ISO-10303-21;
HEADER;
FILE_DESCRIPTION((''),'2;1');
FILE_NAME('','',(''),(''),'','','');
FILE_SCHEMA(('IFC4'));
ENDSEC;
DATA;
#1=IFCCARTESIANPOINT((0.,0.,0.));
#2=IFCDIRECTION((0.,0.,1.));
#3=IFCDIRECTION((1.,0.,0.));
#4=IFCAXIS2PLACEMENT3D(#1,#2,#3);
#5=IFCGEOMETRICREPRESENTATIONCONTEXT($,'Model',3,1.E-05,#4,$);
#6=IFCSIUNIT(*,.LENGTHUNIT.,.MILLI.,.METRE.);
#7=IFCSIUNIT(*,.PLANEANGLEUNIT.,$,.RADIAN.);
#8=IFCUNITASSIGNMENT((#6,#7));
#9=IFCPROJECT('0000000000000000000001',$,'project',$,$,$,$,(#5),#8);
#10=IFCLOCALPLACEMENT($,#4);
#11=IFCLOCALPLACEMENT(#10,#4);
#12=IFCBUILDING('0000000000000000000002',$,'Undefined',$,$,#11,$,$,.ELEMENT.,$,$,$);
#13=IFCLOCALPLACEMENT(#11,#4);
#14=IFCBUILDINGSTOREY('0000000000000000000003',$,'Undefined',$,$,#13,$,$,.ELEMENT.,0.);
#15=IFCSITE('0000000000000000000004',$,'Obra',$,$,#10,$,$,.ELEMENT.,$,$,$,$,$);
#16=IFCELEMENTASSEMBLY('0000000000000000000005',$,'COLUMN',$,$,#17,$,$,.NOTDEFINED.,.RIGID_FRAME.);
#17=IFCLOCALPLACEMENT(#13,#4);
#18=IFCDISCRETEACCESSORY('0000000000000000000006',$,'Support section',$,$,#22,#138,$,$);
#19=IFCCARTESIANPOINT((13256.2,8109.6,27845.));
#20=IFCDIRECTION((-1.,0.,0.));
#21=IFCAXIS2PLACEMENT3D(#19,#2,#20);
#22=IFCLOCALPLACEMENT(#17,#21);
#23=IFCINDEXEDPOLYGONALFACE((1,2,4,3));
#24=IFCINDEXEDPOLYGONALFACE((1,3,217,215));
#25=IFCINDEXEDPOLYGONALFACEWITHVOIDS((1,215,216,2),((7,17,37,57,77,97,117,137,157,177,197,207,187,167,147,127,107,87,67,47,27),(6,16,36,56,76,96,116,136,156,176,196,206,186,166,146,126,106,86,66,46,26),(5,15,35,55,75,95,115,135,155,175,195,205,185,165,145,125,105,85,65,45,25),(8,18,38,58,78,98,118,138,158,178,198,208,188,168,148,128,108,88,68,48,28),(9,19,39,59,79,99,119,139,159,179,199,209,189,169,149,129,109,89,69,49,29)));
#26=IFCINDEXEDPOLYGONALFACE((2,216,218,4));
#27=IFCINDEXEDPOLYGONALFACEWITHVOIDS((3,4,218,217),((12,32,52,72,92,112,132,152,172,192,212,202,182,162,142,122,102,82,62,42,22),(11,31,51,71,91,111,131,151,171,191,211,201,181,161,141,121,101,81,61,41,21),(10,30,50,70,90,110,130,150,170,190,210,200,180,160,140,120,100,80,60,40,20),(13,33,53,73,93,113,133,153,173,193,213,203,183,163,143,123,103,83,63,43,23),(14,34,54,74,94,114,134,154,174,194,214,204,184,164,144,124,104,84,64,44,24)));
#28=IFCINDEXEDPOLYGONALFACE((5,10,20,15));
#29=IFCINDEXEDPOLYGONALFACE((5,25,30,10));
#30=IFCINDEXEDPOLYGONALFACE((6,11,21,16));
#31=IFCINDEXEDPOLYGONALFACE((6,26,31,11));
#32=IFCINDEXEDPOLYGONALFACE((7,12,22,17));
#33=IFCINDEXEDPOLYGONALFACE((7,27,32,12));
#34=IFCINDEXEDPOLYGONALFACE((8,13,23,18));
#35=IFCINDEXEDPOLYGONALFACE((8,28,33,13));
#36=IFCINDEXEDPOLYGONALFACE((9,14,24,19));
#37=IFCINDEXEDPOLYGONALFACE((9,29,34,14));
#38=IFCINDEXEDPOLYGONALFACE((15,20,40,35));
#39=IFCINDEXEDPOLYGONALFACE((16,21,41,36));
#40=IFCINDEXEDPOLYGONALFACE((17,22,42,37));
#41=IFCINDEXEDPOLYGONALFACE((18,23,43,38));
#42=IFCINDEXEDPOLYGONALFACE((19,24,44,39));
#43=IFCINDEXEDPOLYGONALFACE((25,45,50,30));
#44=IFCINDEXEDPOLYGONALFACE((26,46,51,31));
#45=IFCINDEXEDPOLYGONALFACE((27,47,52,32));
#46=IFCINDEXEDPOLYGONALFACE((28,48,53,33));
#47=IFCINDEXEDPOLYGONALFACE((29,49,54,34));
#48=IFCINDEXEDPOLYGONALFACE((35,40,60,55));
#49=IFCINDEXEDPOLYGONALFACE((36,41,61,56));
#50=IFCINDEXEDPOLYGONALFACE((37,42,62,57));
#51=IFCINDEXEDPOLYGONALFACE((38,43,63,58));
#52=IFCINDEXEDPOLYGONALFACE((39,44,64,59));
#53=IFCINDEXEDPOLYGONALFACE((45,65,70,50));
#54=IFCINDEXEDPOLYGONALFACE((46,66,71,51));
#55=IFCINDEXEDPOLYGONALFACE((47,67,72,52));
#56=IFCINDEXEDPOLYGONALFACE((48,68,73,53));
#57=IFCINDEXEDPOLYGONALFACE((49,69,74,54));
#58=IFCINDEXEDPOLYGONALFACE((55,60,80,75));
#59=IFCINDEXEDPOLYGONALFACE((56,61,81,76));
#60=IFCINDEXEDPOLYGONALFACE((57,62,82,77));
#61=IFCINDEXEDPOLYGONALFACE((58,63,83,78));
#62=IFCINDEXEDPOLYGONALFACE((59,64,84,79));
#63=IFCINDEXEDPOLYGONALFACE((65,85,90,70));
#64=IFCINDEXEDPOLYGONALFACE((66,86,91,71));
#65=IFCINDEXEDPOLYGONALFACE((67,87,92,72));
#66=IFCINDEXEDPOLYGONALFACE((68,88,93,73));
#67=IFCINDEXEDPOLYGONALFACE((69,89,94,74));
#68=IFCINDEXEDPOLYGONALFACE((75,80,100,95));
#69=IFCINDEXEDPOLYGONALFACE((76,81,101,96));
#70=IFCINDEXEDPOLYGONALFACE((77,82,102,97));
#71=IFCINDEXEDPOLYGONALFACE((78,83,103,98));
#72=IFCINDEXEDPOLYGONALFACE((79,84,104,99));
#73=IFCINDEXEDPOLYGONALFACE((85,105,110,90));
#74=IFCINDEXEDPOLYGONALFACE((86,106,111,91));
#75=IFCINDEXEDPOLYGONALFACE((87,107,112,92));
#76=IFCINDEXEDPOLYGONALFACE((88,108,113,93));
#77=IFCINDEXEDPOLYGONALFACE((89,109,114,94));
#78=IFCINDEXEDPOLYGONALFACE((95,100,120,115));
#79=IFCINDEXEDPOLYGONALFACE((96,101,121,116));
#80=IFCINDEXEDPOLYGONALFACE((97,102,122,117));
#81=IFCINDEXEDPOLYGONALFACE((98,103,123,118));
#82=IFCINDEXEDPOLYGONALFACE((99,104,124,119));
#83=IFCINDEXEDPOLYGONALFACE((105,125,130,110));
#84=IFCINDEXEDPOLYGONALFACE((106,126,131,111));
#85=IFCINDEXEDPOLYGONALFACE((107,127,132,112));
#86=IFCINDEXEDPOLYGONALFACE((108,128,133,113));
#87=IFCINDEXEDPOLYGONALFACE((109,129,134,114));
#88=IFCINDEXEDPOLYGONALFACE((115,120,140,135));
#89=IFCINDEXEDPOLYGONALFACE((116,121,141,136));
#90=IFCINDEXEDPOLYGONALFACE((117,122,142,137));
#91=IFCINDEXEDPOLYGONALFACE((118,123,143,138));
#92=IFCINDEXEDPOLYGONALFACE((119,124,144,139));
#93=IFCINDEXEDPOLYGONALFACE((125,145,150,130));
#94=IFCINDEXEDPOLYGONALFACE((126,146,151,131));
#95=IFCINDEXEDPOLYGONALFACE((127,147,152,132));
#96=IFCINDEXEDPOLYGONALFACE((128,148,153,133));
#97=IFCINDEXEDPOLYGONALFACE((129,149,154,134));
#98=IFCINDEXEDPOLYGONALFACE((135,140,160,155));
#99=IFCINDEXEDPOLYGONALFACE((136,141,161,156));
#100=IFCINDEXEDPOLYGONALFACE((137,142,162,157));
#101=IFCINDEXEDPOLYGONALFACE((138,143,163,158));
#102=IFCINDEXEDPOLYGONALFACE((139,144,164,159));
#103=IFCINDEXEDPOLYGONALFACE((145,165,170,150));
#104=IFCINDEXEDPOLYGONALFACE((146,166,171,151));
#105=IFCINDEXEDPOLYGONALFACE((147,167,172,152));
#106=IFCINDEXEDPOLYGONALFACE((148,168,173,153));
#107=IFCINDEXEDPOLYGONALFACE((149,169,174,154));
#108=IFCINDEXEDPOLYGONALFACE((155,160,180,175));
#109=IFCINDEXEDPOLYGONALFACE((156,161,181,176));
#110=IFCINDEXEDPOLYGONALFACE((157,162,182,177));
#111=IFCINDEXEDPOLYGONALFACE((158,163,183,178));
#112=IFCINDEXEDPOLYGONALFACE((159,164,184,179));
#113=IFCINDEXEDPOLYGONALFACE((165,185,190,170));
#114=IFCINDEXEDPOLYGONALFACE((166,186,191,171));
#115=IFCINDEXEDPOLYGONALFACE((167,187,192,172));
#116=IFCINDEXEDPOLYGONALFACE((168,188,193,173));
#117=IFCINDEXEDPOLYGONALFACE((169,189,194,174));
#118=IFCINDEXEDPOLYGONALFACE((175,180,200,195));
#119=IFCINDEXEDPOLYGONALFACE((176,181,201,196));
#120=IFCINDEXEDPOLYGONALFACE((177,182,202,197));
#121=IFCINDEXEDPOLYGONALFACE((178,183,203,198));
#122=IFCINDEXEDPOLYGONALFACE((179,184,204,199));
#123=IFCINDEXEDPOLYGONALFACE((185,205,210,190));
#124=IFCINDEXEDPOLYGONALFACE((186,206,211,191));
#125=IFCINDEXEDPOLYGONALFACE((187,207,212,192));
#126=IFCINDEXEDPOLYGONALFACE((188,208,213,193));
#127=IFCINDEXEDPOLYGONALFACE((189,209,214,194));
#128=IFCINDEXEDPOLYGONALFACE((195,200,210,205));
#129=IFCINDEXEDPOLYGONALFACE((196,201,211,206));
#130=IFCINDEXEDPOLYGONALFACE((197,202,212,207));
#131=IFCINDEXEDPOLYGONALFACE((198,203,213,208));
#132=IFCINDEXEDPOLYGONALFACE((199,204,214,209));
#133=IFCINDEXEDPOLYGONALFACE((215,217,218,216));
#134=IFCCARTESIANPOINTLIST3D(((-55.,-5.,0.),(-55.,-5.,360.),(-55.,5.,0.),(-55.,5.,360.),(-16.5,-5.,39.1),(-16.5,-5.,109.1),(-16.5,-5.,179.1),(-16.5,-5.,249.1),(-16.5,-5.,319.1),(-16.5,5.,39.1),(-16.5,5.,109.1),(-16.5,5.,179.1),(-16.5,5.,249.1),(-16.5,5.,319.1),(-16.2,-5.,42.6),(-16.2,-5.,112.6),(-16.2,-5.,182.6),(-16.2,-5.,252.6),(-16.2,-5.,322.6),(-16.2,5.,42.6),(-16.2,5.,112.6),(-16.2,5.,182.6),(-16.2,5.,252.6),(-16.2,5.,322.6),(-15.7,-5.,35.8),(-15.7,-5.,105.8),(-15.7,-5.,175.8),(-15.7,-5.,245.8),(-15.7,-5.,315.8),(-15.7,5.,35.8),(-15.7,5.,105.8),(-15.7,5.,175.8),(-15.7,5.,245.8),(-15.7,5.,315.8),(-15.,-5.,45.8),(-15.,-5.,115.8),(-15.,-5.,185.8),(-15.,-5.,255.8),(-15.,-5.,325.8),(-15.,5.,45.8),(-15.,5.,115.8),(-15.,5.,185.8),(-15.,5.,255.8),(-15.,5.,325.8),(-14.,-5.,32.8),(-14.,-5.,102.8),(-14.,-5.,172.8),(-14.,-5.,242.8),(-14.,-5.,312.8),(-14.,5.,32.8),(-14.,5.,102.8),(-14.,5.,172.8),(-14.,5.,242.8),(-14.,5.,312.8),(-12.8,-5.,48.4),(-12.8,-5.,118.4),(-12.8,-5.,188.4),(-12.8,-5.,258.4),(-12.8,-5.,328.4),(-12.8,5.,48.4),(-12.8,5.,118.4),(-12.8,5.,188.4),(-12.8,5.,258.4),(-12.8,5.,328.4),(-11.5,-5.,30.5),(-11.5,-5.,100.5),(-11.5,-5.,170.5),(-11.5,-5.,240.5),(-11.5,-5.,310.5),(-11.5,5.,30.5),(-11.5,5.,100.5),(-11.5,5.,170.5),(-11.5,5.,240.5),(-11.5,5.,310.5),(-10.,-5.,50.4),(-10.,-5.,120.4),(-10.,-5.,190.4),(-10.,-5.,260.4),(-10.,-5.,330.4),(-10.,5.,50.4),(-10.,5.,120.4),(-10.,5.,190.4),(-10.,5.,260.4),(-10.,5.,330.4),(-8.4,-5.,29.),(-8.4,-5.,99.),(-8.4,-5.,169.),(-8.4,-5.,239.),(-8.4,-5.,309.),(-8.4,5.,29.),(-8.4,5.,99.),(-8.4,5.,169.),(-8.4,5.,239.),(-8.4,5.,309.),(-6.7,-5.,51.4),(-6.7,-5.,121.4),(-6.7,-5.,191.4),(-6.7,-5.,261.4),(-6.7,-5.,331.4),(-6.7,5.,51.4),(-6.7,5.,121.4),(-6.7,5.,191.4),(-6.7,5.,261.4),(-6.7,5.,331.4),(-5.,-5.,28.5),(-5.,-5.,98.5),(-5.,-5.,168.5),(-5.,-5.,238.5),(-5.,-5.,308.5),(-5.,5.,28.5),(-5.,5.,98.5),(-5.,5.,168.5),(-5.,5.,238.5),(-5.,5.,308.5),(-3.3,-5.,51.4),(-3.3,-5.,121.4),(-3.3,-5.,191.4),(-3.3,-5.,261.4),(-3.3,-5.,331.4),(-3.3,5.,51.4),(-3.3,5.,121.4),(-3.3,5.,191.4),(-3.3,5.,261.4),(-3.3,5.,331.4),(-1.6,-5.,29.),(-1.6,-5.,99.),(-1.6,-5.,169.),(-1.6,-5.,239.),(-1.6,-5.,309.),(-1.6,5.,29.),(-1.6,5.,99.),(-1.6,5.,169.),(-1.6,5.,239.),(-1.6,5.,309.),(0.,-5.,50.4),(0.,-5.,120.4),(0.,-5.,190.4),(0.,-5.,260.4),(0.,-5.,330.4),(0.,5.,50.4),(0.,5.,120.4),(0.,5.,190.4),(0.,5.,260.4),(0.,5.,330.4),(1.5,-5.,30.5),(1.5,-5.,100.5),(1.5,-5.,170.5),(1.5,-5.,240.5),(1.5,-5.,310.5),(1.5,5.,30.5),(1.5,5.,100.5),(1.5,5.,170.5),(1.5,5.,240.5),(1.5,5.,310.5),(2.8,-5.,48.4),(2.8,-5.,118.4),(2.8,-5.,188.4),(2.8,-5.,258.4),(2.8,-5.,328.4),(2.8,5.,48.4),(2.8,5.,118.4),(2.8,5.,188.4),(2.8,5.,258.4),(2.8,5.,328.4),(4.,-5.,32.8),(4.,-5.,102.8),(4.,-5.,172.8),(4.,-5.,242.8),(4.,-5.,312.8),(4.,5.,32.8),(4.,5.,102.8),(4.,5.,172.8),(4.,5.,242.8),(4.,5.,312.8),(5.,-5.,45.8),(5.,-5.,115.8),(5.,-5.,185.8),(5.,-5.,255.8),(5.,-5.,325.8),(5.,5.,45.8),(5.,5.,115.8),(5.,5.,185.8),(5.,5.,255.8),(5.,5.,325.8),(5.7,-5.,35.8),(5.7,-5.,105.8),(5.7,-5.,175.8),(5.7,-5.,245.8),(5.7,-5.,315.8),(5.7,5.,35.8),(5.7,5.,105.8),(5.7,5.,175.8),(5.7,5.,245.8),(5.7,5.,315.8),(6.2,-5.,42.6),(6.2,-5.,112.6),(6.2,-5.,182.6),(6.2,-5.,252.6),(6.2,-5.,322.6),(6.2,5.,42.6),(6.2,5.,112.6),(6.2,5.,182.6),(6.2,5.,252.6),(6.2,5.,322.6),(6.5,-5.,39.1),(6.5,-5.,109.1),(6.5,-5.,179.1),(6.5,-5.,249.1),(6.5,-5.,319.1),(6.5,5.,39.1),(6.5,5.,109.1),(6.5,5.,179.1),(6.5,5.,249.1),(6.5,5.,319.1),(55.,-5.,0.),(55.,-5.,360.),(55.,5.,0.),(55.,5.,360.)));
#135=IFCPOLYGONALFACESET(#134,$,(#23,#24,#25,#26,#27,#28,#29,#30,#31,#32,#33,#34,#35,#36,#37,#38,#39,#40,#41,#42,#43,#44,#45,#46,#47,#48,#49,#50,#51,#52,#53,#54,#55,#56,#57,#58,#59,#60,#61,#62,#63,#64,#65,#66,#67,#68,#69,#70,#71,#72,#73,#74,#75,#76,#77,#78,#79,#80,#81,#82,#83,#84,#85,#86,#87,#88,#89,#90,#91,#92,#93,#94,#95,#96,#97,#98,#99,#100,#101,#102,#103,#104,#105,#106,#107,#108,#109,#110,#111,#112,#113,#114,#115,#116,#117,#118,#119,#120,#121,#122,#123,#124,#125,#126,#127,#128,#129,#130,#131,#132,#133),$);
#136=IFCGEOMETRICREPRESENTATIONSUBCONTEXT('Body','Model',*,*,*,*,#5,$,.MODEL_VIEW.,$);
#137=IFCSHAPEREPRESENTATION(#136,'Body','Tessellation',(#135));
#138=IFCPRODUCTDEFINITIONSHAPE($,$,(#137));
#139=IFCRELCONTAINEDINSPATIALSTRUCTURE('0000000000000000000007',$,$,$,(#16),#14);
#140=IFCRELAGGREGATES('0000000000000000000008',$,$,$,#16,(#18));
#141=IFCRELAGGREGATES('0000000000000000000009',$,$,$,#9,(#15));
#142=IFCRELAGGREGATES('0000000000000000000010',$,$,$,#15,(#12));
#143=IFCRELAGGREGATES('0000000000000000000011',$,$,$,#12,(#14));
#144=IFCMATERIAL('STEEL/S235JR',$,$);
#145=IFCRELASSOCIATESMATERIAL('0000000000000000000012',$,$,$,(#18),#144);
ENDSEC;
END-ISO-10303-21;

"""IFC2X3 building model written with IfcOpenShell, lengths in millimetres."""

from ifc_helpers import new_model, si_unit, frame, origin_with_axes, origin_2d_with_axis, place, context, subcontext, project, spatial, rectangle, circle, extrude, source, transform, mapped, material, element, aggregate, save


model = new_model("IFC2X3")

# Units and contexts
model_context = context("Model", 3, precision=1e-05, world=origin_with_axes())
body_context = subcontext(model_context, "Body", "Model", "MODEL_VIEW")
ifc_project = project(units=[si_unit("LENGTHUNIT", "METRE", prefix="MILLI"), si_unit("PLANEANGLEUNIT", "RADIAN")], contexts=[model_context])

# Site, building, storey
site_placement = place(None, origin_with_axes())
site = spatial("IfcSite", under=ifc_project, at=site_placement, Name="Obra", CompositionType="ELEMENT")
building_placement = place(site_placement, origin_with_axes())
building = spatial("IfcBuilding", under=site, at=building_placement, Name="Undefined", CompositionType="ELEMENT")
storey_placement = place(building_placement, origin_with_axes())
storey = spatial("IfcBuildingStorey", under=building, at=storey_placement, Name="Undefined", CompositionType="ELEMENT", Elevation=0.0)

# Element assembly
ifc_material_1 = material(Name="STEEL/S235JR")
assembly_1_placement = place(storey_placement, origin_with_axes())
assembly_1 = element("IfcElementAssembly", 1, at=assembly_1_placement, inside=storey, Name="COLUMN", AssemblyPlace="NOTDEFINED", PredefinedType="RIGID_FRAME")

# Discrete accessory, opening
shared_shape_1 = source(origin_with_axes(), body_context, "Body", "SweptSolid", [
    extrude(circle(Radius=11.5, at=origin_2d_with_axis()), frame((0.0, -15.7, 0.0), z_axis=(0.0, 1.0, 0.0), x_axis=(1.0, 0.0, 0.0)), (0.0, 0.0, 1.0), 10.2),
])
discrete_accessory_1_placement = place(assembly_1_placement, frame((13256.2, 8109.6, 27845.0), z_axis=(0.0, 0.0, 1.0), x_axis=(-1.0, 0.0, 0.0)))
discrete_accessory_1 = element("IfcDiscreteAccessory", 2, at=discrete_accessory_1_placement, material=ifc_material_1, Name="Support section", context=body_context, shape_type="SweptSolid", body=[
    extrude(rectangle(XDim=10.0, YDim=110.0, at=origin_2d_with_axis()), frame((0.0, 0.0, 360.0), z_axis=(0.0, 0.0, -1.0), x_axis=(0.0, 1.0, 0.0)), (0.0, 0.0, 1.0), 360.0),
])
opening_1_placement = place(assembly_1_placement, frame((13211.2, 8120.1, 28300.0), z_axis=(1.0, 0.0, 0.0), x_axis=(0.0, 0.0, -1.0)))
element("IfcOpeningElement", 3, at=opening_1_placement, cuts=discrete_accessory_1, ObjectType="Opening", context=body_context, shape_type="MappedRepresentation", body=[
    mapped(shared_shape_1, transform((135.0, 0.0, 50.0))),
    mapped(shared_shape_1, transform((205.0, 0.0, 50.0))),
    mapped(shared_shape_1, transform((275.0, 0.0, 50.0))),
    mapped(shared_shape_1, transform((345.0, 0.0, 50.0))),
    mapped(shared_shape_1, transform((415.0, 0.0, 50.0))),
])
aggregate(assembly_1, [discrete_accessory_1])

save(model, "model.ifc")
